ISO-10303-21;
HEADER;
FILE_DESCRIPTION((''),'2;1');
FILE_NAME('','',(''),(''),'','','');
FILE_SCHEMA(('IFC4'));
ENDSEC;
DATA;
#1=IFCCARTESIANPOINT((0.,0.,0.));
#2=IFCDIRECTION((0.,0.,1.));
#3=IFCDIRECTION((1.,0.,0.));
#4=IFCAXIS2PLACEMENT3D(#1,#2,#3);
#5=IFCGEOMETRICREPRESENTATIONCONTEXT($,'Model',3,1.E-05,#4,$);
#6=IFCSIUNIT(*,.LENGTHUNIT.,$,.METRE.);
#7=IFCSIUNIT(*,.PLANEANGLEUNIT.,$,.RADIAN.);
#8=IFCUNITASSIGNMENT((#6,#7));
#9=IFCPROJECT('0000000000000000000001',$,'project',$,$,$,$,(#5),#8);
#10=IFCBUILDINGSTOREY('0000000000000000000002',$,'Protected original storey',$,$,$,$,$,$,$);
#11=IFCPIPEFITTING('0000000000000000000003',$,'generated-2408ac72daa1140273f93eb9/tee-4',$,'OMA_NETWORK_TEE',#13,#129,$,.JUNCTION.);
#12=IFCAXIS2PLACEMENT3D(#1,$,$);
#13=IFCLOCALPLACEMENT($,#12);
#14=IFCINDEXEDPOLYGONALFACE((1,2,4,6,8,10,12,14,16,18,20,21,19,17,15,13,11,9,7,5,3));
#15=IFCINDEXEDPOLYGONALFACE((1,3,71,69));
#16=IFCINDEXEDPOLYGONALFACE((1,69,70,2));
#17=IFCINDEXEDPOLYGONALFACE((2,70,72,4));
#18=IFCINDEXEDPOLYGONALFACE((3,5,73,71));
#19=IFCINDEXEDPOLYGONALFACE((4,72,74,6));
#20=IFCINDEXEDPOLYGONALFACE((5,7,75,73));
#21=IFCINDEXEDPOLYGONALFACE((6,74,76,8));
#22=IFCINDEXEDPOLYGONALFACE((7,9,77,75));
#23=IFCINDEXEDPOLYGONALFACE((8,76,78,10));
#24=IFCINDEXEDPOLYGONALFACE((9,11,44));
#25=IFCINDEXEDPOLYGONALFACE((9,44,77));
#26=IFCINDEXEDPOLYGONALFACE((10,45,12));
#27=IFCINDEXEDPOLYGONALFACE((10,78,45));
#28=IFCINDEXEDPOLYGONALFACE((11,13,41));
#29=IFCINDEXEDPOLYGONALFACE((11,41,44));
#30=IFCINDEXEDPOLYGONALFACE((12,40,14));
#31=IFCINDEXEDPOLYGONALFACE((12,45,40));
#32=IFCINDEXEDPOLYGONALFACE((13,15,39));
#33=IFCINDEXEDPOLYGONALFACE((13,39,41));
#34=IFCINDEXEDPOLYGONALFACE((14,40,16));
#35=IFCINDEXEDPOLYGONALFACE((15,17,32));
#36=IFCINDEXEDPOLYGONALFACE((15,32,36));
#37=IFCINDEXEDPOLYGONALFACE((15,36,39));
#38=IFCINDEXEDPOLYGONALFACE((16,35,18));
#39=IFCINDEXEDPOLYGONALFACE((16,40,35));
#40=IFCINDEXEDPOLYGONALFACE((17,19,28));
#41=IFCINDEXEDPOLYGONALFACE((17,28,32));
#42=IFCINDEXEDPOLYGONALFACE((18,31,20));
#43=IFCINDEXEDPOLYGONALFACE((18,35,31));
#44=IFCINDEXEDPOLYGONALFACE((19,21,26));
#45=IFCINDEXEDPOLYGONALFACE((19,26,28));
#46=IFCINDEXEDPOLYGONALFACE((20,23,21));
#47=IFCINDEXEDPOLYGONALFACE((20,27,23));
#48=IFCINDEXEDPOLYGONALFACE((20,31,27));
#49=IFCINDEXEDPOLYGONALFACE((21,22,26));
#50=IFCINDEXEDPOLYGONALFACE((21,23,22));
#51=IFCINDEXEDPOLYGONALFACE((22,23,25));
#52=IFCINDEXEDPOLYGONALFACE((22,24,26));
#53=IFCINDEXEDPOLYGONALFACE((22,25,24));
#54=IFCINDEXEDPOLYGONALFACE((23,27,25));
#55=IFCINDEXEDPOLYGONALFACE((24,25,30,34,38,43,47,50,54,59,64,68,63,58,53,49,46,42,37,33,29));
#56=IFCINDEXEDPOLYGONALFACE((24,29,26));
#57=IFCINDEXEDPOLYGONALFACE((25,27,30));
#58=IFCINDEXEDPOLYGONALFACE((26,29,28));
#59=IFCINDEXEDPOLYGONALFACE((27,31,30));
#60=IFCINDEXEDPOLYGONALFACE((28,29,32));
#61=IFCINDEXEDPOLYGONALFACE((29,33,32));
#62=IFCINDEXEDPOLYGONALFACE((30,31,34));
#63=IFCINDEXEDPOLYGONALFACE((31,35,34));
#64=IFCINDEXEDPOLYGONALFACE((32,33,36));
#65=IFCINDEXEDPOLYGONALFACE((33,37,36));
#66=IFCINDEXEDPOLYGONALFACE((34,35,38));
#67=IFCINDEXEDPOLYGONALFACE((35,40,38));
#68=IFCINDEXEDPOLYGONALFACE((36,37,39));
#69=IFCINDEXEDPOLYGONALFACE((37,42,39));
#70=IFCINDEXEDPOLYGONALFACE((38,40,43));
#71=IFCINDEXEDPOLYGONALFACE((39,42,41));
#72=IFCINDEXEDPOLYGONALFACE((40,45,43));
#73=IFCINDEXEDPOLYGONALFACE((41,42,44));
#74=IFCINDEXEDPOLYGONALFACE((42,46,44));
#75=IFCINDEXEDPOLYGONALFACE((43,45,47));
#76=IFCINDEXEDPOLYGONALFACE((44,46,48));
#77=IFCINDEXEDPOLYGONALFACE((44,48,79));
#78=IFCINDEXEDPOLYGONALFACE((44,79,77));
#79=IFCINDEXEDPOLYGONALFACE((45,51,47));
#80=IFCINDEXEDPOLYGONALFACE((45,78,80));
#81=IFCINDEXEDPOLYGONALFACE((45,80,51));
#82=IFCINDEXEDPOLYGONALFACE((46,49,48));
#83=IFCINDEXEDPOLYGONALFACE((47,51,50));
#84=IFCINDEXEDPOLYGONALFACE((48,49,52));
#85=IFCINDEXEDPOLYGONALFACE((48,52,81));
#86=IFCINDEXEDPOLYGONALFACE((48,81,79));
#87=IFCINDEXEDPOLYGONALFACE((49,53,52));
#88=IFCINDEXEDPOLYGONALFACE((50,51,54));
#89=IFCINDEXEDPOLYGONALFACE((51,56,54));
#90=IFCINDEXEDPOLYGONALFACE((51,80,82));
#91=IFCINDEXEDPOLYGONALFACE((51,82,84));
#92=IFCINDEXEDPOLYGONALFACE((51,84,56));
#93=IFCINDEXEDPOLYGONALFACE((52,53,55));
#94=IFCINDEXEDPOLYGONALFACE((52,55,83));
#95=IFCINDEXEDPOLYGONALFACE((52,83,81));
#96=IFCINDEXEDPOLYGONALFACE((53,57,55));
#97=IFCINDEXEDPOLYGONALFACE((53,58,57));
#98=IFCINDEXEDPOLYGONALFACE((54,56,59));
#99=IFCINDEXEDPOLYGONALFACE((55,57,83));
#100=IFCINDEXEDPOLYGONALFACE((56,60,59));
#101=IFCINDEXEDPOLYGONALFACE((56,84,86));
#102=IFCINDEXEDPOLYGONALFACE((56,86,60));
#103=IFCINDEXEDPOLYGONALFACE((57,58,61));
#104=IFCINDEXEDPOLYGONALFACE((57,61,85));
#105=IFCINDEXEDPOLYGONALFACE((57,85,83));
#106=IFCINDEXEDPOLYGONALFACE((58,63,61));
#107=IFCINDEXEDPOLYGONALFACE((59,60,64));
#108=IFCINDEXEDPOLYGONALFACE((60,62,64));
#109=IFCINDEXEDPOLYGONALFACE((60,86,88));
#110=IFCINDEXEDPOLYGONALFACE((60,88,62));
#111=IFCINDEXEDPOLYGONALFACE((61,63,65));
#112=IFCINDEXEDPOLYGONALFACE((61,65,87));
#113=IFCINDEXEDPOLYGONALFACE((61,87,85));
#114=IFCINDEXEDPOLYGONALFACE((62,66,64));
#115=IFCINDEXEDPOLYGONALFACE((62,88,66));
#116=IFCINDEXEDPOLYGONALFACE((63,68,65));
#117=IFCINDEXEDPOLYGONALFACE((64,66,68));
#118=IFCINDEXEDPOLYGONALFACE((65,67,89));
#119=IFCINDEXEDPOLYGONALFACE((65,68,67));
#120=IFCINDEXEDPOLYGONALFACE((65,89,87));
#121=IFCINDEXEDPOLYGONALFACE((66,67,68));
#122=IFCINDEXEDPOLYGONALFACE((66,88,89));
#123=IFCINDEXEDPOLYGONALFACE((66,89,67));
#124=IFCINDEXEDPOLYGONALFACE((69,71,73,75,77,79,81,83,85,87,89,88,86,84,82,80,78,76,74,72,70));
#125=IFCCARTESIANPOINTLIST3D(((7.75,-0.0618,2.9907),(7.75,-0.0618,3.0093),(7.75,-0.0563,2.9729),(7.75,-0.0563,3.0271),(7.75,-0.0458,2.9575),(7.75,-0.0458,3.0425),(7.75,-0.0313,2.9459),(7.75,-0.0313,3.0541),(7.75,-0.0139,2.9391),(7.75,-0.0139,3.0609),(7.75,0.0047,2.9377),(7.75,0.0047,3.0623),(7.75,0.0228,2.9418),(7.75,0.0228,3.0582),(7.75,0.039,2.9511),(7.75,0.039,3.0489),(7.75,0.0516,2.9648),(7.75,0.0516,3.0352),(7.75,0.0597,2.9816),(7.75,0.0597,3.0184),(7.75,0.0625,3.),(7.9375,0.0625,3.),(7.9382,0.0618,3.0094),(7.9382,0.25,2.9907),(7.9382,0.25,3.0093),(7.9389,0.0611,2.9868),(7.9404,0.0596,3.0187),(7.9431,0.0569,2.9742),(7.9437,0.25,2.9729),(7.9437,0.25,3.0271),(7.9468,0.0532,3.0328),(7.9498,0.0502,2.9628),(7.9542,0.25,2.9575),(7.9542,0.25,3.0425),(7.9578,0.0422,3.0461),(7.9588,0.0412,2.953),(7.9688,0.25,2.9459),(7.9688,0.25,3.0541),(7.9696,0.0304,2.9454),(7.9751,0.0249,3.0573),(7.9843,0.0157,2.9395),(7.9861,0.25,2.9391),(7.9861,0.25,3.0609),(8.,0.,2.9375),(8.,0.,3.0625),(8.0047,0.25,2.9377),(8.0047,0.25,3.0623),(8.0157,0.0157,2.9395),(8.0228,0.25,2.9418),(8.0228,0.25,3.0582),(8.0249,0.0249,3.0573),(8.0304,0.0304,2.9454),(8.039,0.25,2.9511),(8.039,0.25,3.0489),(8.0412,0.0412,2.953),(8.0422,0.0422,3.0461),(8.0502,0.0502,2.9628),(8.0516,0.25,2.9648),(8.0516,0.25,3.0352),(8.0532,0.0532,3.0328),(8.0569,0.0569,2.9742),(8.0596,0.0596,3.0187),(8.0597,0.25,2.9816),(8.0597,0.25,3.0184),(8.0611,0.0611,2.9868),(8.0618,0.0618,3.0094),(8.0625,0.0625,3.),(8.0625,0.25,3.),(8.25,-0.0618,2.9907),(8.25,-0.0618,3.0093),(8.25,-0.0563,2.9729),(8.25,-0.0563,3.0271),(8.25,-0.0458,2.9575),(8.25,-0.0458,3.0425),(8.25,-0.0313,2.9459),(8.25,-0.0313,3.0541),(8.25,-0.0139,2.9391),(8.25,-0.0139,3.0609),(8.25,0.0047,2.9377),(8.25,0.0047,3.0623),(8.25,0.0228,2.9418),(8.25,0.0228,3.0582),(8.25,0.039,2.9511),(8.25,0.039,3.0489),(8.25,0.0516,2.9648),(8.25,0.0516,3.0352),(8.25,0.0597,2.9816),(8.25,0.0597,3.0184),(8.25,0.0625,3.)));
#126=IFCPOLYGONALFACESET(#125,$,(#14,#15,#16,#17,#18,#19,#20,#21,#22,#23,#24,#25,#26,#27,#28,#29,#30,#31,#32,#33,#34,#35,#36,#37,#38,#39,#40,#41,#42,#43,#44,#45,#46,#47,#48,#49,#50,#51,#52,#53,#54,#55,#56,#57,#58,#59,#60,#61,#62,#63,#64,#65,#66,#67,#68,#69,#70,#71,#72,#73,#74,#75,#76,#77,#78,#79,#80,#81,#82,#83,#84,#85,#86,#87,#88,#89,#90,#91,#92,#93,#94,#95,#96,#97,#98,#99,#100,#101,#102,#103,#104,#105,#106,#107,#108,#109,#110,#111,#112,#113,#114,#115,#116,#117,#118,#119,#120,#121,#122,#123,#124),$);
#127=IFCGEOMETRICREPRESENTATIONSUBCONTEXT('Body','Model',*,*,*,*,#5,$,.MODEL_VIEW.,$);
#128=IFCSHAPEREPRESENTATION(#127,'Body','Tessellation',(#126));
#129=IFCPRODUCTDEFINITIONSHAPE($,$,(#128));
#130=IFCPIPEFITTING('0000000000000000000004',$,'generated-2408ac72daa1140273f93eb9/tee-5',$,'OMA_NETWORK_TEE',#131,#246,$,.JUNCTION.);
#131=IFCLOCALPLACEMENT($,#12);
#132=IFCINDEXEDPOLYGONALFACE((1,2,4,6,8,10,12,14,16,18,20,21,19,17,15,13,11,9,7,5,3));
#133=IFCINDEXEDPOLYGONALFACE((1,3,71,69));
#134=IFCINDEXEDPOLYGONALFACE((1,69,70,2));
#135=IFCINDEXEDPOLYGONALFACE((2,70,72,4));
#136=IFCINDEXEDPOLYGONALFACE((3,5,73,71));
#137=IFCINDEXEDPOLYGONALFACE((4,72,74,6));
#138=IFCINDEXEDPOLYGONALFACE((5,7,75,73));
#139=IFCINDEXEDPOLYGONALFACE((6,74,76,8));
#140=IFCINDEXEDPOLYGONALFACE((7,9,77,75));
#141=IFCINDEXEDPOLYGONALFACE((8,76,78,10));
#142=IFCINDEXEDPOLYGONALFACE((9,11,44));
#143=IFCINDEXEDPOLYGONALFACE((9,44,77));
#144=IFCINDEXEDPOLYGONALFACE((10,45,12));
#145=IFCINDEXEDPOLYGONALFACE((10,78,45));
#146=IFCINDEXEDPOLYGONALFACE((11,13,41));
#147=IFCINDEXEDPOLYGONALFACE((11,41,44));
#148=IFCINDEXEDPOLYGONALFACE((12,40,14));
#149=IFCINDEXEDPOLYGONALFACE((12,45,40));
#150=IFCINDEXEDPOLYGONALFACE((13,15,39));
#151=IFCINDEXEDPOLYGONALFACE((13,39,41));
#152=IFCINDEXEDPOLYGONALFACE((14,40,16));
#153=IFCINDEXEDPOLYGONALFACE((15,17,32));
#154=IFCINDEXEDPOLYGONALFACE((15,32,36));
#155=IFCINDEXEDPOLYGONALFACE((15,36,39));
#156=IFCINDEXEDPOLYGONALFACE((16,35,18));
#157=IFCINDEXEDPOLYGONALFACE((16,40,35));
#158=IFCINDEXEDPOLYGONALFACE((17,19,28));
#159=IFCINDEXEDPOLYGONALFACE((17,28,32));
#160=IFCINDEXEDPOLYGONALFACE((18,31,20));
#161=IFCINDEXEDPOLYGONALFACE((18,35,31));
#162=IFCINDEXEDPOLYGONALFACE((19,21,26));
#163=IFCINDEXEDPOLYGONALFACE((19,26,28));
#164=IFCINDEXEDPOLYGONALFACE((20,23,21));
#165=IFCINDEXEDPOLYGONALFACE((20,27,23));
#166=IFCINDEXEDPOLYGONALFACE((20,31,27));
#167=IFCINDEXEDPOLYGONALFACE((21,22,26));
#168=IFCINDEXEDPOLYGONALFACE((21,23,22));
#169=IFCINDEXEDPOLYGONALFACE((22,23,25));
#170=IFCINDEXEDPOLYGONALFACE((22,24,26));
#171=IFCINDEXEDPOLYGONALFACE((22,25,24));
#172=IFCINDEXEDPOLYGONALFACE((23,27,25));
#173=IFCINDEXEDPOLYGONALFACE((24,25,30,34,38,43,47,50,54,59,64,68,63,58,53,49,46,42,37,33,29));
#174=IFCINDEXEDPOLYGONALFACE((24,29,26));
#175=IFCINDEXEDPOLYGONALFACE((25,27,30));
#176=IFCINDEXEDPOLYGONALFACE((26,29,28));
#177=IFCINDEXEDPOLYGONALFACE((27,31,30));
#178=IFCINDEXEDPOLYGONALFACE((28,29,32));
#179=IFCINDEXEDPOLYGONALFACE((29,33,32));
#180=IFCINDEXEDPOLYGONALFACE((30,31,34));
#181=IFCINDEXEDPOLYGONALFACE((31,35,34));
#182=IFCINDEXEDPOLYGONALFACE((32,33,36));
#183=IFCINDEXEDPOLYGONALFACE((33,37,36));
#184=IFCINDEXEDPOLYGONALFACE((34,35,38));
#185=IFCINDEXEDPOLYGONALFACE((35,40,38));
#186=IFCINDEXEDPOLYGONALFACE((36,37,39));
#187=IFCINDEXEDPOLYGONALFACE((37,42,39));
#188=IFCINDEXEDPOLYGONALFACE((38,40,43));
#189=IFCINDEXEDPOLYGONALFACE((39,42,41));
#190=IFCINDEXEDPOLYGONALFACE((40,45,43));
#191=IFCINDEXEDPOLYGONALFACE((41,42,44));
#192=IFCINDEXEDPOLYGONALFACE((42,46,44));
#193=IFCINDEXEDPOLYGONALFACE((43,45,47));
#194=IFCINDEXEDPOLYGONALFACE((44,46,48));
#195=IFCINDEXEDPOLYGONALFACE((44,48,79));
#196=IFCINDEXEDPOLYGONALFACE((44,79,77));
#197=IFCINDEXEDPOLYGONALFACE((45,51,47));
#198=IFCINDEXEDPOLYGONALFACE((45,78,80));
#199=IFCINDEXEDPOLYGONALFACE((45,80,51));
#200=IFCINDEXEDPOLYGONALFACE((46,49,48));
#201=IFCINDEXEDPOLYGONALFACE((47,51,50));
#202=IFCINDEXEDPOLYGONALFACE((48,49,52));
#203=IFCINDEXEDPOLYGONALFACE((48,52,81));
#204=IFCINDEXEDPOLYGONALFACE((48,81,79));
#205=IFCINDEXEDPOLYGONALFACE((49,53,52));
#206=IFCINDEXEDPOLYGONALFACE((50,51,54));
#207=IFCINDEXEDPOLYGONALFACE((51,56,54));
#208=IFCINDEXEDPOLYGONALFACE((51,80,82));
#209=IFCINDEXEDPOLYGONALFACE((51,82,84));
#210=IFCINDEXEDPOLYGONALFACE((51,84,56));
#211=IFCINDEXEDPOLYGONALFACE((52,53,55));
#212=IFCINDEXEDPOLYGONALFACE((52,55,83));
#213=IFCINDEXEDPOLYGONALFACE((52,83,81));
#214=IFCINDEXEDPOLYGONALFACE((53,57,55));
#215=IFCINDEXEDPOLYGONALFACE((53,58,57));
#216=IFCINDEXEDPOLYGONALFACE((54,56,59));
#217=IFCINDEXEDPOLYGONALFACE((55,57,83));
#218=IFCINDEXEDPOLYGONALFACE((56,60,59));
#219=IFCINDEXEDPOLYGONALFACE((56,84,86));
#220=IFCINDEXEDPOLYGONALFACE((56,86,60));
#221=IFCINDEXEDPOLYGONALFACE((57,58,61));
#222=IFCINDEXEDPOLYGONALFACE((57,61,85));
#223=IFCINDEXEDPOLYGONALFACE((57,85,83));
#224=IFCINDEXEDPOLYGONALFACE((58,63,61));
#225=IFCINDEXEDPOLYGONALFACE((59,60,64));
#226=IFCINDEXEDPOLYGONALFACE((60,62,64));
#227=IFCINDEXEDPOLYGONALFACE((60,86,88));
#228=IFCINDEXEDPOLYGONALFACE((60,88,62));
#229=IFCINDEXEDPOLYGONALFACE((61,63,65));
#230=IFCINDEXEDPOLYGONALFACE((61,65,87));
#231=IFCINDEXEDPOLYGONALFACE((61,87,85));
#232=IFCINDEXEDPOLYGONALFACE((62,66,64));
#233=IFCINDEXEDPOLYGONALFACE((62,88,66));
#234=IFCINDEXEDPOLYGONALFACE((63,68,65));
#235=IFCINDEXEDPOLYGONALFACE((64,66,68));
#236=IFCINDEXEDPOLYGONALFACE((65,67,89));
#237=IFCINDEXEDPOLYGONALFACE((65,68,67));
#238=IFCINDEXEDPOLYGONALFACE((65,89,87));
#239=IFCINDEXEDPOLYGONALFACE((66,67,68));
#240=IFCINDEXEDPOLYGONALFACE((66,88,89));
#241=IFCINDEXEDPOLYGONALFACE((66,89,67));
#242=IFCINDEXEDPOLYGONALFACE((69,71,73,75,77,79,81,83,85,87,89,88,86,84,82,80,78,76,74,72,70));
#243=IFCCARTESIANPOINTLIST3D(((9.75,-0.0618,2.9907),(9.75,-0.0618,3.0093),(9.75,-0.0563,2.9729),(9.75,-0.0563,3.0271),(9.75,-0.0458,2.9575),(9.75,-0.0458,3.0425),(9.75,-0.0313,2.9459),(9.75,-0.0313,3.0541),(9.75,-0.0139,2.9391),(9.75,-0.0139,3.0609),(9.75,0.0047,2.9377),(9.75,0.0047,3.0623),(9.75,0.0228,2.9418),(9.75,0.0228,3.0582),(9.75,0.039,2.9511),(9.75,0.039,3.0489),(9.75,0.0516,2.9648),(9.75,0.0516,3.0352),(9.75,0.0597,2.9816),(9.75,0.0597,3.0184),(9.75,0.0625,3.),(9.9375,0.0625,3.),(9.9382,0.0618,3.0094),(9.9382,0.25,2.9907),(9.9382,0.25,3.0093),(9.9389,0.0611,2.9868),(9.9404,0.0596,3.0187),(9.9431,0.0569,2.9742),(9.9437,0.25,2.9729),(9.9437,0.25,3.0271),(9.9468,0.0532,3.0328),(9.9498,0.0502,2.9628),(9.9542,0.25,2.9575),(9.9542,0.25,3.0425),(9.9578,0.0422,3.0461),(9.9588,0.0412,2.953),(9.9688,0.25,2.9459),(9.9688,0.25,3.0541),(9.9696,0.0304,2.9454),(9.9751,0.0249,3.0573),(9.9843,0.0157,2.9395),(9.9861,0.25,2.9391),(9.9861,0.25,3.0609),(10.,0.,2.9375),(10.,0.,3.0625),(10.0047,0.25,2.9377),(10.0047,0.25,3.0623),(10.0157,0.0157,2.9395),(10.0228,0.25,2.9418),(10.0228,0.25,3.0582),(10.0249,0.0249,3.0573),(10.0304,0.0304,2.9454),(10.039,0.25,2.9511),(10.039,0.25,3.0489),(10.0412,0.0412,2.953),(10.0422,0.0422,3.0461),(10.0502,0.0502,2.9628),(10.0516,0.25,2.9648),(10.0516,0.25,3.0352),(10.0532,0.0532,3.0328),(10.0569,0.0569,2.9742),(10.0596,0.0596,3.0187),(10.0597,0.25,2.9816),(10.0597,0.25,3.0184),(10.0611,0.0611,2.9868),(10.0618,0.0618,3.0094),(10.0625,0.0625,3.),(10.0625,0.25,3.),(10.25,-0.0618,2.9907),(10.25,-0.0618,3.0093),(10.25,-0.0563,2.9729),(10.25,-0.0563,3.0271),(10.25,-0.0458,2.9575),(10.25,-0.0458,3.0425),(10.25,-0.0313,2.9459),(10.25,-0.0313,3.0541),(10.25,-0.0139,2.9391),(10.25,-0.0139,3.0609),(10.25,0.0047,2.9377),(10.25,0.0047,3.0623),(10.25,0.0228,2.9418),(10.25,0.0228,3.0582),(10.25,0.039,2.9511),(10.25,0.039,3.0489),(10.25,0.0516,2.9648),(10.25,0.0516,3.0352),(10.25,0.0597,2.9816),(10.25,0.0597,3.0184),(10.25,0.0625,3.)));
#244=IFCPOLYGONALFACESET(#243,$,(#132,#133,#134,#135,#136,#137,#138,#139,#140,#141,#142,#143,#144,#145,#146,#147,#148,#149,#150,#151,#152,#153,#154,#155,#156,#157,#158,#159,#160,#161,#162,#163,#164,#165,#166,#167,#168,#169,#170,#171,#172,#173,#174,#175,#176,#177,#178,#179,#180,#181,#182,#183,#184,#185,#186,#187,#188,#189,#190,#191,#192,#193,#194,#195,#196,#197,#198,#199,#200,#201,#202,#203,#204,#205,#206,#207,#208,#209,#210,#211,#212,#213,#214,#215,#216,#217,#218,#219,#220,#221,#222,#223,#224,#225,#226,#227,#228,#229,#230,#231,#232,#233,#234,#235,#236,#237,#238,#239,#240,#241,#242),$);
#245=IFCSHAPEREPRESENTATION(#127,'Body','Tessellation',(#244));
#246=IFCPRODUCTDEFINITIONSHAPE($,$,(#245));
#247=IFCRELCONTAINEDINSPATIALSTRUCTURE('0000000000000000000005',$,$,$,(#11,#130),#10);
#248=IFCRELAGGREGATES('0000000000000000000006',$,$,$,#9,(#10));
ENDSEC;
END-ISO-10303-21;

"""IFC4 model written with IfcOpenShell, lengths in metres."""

from ifc_helpers import new_model, si_unit, frame, origin_with_axes, origin_2d, place, context, subcontext, project, spatial, circle, extrude, boolean, element, save


model = new_model("IFC4")

# Units and contexts
model_context = context("Model", 3, precision=1e-05, world=origin_with_axes())
body_context = subcontext(model_context, "Body", "Model", "MODEL_VIEW")
ifc_project = project(units=[si_unit("LENGTHUNIT", "METRE"), si_unit("PLANEANGLEUNIT", "RADIAN")], contexts=[model_context])

# Storey
storey = spatial("IfcBuildingStorey", under=ifc_project, Name="Protected original storey")

# Pipe fittings
pipe_fitting_1_placement = place(None, origin_with_axes())
element("IfcPipeFitting", 1, at=pipe_fitting_1_placement, inside=storey, Name="generated-2408ac72daa1140273f93eb9/tee-4", ObjectType="OMA_NETWORK_TEE", PredefinedType="JUNCTION", context=body_context, shape_type="CSG", body=[
    boolean("UNION", extrude(circle(Radius=0.0625, at=origin_2d()), frame((7.75, 0.0, 3.0), z_axis=(1.0, 0.0, 0.0), x_axis=(0.0, 1.0, 0.0)), (0.0, 0.0, 1.0), 0.5), extrude(circle(Radius=0.0625, at=origin_2d()), frame((8.0, 0.0, 3.0), z_axis=(0.0, 1.0, 0.0), x_axis=(1.0, 0.0, 0.0)), (0.0, 0.0, 1.0), 0.25)),
])
pipe_fitting_2_placement = place(None, origin_with_axes())
element("IfcPipeFitting", 2, at=pipe_fitting_2_placement, inside=storey, Name="generated-2408ac72daa1140273f93eb9/tee-5", ObjectType="OMA_NETWORK_TEE", PredefinedType="JUNCTION", context=body_context, shape_type="CSG", body=[
    boolean("UNION", extrude(circle(Radius=0.0625, at=origin_2d()), frame((9.75, 0.0, 3.0), z_axis=(1.0, 0.0, 0.0), x_axis=(0.0, 1.0, 0.0)), (0.0, 0.0, 1.0), 0.5), extrude(circle(Radius=0.0625, at=origin_2d()), frame((10.0, 0.0, 3.0), z_axis=(0.0, 1.0, 0.0), x_axis=(1.0, 0.0, 0.0)), (0.0, 0.0, 1.0), 0.25)),
])

save(model, "model.ifc")
